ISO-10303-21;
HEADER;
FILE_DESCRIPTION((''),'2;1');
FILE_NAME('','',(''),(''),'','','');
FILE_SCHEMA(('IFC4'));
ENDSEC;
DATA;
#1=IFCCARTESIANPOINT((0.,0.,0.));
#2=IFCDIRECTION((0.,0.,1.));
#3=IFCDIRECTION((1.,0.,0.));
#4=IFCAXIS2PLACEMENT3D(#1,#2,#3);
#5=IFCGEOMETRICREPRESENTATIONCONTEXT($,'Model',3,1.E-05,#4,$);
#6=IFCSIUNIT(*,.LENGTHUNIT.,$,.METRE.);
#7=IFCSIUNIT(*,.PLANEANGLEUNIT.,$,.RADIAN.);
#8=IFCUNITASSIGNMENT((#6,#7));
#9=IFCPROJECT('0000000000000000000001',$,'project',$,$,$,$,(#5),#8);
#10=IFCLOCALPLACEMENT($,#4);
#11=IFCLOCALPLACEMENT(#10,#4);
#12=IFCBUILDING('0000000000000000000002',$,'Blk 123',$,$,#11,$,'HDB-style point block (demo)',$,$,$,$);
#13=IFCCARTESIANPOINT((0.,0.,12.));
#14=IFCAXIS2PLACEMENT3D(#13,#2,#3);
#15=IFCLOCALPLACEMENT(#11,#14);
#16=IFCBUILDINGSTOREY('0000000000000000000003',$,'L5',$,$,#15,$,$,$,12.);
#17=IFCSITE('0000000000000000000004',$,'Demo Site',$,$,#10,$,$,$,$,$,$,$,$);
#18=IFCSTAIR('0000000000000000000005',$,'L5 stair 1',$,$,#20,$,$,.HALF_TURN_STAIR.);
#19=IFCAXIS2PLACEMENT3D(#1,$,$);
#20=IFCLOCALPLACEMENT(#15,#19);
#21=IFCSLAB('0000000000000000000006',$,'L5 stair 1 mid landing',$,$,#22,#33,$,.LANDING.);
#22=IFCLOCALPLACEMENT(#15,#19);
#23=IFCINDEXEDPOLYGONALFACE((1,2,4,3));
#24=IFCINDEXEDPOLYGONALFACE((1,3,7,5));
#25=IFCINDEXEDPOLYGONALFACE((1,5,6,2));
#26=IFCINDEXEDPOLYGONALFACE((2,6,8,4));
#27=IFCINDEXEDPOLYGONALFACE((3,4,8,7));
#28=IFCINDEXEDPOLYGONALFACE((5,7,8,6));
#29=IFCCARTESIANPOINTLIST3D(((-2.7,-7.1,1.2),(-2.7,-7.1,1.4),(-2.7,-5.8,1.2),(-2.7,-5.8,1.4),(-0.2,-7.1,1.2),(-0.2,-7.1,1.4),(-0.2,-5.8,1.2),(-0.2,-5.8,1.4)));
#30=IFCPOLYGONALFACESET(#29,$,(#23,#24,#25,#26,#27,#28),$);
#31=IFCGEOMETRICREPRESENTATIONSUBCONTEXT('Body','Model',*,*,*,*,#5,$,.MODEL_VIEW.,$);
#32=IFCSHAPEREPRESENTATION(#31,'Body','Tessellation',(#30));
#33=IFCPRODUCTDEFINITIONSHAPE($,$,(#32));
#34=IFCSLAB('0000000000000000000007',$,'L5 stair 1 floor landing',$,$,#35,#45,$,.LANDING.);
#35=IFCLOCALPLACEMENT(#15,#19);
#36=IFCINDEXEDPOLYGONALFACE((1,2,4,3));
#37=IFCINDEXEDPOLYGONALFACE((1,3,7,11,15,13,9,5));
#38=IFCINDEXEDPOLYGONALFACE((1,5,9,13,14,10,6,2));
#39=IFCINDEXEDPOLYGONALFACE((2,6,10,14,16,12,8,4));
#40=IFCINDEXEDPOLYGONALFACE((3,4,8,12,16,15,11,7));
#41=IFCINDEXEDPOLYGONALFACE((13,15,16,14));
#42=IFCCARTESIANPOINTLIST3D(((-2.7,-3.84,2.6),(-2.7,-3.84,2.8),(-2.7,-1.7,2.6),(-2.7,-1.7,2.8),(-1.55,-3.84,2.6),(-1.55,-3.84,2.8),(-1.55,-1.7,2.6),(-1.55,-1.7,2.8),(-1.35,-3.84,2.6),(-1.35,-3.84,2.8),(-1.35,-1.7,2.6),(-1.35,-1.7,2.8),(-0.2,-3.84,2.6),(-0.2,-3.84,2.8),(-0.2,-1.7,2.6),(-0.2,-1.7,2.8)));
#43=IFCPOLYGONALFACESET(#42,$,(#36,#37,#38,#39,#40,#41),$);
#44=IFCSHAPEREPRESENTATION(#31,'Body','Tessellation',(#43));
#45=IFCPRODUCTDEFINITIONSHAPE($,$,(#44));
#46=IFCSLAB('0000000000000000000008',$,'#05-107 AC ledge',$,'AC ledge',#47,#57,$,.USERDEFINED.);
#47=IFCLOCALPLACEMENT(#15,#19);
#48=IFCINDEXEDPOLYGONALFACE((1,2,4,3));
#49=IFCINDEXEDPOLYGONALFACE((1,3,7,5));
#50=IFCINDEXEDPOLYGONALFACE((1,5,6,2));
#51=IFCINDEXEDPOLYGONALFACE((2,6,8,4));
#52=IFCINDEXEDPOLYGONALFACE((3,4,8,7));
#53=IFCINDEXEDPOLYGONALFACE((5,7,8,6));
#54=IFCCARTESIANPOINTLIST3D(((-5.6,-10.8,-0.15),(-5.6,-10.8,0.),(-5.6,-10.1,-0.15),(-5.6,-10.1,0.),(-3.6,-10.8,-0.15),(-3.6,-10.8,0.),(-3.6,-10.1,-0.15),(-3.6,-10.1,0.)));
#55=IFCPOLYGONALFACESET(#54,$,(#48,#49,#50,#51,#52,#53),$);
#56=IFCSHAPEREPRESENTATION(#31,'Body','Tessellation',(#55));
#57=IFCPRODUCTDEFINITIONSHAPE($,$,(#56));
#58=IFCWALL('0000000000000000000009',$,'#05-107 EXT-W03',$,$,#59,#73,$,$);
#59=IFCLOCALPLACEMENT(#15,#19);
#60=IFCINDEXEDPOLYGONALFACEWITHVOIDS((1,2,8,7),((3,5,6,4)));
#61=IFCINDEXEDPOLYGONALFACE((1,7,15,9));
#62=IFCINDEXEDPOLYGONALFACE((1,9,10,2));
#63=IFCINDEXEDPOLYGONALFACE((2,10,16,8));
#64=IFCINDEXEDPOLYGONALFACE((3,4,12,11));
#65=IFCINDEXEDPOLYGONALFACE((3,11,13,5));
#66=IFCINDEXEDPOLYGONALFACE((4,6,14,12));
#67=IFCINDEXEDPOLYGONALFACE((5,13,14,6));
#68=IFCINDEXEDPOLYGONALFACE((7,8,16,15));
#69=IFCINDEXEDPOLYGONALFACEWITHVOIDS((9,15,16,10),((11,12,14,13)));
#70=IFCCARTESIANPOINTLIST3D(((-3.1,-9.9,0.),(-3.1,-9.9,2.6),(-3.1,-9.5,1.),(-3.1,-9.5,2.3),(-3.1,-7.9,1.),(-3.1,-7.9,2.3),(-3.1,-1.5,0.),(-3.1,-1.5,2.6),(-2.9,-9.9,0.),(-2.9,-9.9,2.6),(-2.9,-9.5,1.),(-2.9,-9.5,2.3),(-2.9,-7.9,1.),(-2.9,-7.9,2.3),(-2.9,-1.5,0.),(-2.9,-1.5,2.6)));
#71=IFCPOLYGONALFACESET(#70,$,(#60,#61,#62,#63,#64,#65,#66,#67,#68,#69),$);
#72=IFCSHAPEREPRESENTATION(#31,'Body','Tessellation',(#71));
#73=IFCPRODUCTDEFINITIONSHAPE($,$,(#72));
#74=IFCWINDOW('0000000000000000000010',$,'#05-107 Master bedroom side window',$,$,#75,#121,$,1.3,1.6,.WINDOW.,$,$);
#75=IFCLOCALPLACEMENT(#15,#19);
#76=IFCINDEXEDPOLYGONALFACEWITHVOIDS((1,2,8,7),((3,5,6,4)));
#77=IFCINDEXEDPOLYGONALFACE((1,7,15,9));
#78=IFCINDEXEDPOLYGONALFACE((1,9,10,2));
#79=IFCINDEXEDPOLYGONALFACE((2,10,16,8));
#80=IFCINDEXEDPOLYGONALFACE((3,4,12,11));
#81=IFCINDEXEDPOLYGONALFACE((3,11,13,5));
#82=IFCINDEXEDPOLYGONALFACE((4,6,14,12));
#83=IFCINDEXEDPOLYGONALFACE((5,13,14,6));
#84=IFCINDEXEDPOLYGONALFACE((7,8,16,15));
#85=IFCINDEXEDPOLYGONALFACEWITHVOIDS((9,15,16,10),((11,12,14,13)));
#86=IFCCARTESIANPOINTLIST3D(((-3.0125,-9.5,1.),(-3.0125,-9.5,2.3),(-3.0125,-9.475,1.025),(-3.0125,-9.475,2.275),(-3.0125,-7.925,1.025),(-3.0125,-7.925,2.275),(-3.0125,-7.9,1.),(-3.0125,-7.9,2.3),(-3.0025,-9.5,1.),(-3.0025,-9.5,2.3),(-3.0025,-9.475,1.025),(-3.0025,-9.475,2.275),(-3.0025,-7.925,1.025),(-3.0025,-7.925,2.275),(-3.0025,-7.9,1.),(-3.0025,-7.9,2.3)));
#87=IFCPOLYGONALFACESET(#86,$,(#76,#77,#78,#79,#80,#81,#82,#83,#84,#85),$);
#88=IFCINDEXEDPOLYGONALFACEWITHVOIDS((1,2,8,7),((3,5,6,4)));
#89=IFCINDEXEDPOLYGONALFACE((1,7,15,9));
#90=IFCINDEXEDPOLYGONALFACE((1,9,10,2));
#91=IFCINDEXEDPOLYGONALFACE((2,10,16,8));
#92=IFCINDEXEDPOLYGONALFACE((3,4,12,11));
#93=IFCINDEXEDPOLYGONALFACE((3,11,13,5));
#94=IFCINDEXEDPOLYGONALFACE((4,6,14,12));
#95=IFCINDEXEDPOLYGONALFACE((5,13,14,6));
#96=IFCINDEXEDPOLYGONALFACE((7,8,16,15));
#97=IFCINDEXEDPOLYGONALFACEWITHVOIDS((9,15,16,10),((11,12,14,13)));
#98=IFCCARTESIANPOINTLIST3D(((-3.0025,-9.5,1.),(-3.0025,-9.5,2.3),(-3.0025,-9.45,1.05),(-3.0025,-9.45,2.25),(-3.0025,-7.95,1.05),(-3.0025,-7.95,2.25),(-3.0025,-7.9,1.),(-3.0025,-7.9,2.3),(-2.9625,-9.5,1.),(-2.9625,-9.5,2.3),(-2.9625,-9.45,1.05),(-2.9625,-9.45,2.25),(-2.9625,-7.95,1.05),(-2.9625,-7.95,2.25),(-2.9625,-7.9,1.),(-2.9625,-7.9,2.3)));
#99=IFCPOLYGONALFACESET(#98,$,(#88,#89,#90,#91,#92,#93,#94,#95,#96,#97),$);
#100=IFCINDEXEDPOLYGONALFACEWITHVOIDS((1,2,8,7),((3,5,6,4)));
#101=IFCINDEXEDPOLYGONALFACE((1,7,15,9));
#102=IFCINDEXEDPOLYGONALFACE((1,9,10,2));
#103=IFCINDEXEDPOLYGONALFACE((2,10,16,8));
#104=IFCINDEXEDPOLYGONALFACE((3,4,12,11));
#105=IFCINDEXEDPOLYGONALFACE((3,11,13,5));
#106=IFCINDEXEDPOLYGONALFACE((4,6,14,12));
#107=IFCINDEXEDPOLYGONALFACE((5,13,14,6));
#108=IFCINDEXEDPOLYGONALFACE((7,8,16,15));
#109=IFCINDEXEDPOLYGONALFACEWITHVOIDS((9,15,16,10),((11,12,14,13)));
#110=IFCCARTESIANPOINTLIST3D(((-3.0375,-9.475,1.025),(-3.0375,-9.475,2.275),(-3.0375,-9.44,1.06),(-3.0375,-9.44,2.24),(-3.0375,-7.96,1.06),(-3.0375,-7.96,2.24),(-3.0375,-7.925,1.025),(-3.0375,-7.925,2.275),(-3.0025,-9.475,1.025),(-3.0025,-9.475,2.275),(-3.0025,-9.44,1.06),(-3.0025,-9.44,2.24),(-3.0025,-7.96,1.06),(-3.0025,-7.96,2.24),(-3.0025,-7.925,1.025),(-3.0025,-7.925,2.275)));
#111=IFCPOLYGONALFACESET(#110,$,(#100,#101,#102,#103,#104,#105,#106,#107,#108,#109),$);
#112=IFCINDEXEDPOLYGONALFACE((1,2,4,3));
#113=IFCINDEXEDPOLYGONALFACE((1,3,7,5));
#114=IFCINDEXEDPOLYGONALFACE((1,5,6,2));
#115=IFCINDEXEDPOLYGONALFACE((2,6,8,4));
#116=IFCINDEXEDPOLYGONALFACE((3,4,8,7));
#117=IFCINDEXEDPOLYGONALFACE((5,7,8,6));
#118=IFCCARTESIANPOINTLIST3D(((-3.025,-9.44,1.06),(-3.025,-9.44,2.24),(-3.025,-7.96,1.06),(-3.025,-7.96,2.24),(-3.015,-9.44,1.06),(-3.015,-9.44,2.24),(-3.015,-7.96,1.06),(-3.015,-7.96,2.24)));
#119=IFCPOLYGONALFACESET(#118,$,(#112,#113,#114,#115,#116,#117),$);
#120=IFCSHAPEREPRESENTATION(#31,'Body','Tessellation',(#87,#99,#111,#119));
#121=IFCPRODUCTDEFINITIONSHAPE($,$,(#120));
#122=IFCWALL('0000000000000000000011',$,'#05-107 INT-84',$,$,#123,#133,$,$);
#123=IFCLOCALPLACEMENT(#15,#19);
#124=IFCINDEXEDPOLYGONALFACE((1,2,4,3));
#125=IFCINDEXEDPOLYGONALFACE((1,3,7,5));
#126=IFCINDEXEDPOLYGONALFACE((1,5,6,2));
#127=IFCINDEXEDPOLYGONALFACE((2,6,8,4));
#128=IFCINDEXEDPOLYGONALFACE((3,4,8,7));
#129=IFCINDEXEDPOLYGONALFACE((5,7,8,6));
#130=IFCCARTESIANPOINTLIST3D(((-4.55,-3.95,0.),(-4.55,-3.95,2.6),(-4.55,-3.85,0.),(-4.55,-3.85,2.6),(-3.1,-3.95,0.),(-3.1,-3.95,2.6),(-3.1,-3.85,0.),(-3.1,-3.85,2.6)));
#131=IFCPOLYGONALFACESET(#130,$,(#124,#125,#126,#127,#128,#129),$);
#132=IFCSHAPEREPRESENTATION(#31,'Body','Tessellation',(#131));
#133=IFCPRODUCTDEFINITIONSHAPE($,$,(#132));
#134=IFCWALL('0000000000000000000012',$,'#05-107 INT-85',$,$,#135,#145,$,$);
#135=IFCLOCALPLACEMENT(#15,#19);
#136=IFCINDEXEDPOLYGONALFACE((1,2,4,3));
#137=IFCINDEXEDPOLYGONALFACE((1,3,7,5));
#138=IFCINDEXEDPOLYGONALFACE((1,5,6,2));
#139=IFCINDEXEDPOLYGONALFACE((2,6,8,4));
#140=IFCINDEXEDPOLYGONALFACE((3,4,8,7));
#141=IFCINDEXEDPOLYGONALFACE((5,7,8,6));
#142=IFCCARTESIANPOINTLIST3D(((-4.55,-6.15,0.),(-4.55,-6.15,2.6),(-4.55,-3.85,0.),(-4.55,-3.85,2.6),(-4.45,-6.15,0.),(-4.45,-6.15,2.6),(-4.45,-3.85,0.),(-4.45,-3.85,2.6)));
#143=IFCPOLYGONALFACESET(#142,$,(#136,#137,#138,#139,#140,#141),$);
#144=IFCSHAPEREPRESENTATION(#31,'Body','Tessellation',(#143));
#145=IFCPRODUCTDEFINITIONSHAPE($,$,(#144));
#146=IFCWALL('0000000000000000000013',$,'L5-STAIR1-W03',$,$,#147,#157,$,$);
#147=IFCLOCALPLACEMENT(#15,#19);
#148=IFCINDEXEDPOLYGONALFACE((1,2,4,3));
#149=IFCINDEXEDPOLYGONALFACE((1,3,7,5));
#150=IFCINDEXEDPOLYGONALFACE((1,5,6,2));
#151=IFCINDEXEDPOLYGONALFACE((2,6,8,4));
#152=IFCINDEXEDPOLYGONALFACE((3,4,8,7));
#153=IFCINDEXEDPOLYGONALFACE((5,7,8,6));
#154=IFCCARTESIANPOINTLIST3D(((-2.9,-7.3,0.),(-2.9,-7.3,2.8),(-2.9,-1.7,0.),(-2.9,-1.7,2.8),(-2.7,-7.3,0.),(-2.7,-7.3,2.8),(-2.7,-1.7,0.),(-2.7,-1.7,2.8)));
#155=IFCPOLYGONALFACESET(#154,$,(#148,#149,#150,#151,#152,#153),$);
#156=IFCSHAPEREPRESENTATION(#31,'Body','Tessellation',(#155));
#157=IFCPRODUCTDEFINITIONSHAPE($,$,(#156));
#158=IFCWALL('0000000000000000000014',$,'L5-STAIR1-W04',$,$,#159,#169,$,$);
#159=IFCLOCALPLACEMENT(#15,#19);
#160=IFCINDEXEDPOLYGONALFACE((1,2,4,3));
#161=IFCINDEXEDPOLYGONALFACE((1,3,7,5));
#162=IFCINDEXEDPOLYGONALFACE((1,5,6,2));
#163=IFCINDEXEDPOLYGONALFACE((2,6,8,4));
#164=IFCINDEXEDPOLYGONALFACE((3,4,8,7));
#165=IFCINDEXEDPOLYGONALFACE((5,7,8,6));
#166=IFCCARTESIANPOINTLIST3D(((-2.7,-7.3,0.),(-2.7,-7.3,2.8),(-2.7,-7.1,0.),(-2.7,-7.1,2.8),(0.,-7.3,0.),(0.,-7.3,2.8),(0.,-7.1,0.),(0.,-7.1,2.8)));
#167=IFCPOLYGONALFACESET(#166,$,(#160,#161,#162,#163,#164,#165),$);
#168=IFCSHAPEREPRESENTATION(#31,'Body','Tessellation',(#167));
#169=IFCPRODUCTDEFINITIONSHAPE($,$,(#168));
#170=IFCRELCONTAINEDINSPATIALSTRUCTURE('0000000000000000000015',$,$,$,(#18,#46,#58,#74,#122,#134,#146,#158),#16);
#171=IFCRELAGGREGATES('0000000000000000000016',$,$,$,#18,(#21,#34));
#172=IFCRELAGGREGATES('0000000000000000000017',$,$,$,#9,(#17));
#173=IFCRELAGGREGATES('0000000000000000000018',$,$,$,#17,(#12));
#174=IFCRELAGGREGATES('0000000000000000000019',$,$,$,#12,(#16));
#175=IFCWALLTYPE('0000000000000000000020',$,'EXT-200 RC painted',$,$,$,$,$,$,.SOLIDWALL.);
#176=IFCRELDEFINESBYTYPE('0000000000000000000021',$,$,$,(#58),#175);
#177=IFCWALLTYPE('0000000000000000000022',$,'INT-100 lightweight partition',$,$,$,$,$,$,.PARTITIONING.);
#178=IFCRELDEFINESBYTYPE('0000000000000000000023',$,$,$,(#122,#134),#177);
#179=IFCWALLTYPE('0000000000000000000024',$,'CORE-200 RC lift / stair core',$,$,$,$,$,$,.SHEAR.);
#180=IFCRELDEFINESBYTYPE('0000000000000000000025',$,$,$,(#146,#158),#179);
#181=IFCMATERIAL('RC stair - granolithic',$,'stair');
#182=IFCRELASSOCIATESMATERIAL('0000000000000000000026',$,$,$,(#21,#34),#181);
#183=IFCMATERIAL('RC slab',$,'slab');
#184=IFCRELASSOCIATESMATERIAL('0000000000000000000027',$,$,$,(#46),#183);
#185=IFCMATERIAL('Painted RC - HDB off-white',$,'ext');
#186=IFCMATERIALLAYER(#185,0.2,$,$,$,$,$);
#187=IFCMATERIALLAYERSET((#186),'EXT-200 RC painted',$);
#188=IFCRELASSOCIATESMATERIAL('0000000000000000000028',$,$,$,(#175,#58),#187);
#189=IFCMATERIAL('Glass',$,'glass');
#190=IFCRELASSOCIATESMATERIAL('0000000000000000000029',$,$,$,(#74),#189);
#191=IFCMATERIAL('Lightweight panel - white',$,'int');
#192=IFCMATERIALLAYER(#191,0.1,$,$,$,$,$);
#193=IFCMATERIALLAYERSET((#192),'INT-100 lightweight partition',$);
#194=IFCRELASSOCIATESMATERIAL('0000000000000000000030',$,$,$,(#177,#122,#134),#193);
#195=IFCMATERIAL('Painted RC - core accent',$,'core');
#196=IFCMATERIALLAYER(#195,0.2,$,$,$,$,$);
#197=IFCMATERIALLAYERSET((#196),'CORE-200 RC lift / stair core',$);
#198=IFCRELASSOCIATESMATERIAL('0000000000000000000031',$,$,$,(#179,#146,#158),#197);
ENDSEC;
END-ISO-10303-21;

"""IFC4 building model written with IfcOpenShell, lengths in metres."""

from ifc_helpers import new_model, si_unit, frame, origin, origin_with_axes, place, context, subcontext, project, spatial, polyline, line, indexed_curve, outline, extrude, material, layer, layer_set, layer_usage, type_object, element, fill, aggregate, save


model = new_model("IFC4")

# Units and contexts
model_context = context("Model", 3, precision=1e-05, world=origin_with_axes())
body_context = subcontext(model_context, "Body", "Model", "MODEL_VIEW")
ifc_project = project(units=[si_unit("LENGTHUNIT", "METRE"), si_unit("PLANEANGLEUNIT", "RADIAN")], contexts=[model_context])

# Site, building, storey
site_placement = place(None, origin_with_axes())
site = spatial("IfcSite", under=ifc_project, at=site_placement, Name="Demo Site")
building_placement = place(site_placement, origin_with_axes())
building = spatial("IfcBuilding", under=site, at=building_placement, Name="Blk 123", LongName="HDB-style point block (demo)")
storey_placement = place(building_placement, frame((0.0, 0.0, 12.0), z_axis=(0.0, 0.0, 1.0), x_axis=(1.0, 0.0, 0.0)))
storey = spatial("IfcBuildingStorey", under=building, at=storey_placement, Name="L5", Elevation=12.0)

# Stair, slabs
stair_placement = place(storey_placement, frame((-2.7, -7.1, 0.0), z_axis=(0.0, 0.0, 1.0), x_axis=(1.0, 0.0, 0.0)))
stair = element("IfcStair", 1, at=stair_placement, inside=storey, Name="L5 stair 1", PredefinedType="HALF_TURN_STAIR")
ifc_material_1 = material(Name="RC stair - granolithic", Category="stair")
slab_1_placement = place(stair_placement, frame((1.25, 0.65, 1.2), z_axis=(0.0, 0.0, 1.0), x_axis=(1.0, 0.0, 0.0)))
slab_1 = element("IfcSlab", 2, at=slab_1_placement, material=ifc_material_1, Name="L5 stair 1 mid landing", PredefinedType="LANDING", context=body_context, shape_type="SweptSolid", body=[
    extrude(outline(polyline([(1.25, -0.65), (1.25, 0.65), (-1.25, 0.65), (-1.25, -0.65), (1.25, -0.65)])), origin(), (0.0, 0.0, 1.0), 0.2),
])
slab_2_placement = place(stair_placement, frame((1.25, 4.33, 2.6), z_axis=(0.0, 0.0, 1.0), x_axis=(1.0, 0.0, 0.0)))
slab_2 = element("IfcSlab", 3, at=slab_2_placement, material=ifc_material_1, Name="L5 stair 1 floor landing", PredefinedType="LANDING", context=body_context, shape_type="SweptSolid", body=[
    extrude(outline(polyline([(-0.1, 1.07), (-1.25, 1.07), (-1.25, -1.07), (-0.1, -1.07), (0.1, -1.07), (1.25, -1.07), (1.25, 1.07), (0.1, 1.07), (-0.1, 1.07)])), origin(), (0.0, 0.0, 1.0), 0.2),
])

# Slab
ifc_material_2 = material(Name="RC slab", Category="slab")
slab_3_placement = place(storey_placement, frame((-4.6, -10.45, -0.15), z_axis=(0.0, 0.0, 1.0), x_axis=(1.0, 0.0, 0.0)))
element("IfcSlab", 4, at=slab_3_placement, inside=storey, material=ifc_material_2, Name="#05-107 AC ledge", ObjectType="AC ledge", PredefinedType="USERDEFINED", context=body_context, shape_type="SweptSolid", body=[
    extrude(outline(polyline([(-1.0, 0.35), (-1.0, -0.35), (1.0, -0.35), (1.0, 0.35), (-1.0, 0.35)])), origin(), (0.0, 0.0, 1.0), 0.15),
])

# Wall, opening, window
ifc_material_3 = material(Name="Painted RC - HDB off-white", Category="ext")
ifc_layer_1 = layer(ifc_material_3, 0.2)
ifc_layer_set_1 = layer_set([ifc_layer_1], Name="EXT-200 RC painted")
ifc_layer_usage_1 = layer_usage(ifc_layer_set_1, "AXIS2", "POSITIVE", 0.0)
wall_type_1 = type_object("IfcWallType", Name="EXT-200 RC painted", PredefinedType="SOLIDWALL", material=ifc_layer_set_1)
wall_1_placement = place(storey_placement, frame((-2.9, -9.9, 0.0), z_axis=(0.0, 0.0, 1.0), x_axis=(0.0, 1.0, 0.0)))
wall_1 = element("IfcWall", 5, at=wall_1_placement, inside=storey, type_object=wall_type_1, material=ifc_layer_usage_1, Name="#05-107 EXT-W03", context=body_context, shape_type="SweptSolid", body=[
    extrude(outline(indexed_curve([(0.0, 0.0), (0.0, 0.2), (8.4, 0.2), (8.4, 0.0), (0.0, 0.0)], self_intersect=False)), origin_with_axes(), (0.0, 0.0, 1.0), 2.6),
])
opening_1_placement = place(wall_1_placement, frame((0.4, -0.1, 1.0), z_axis=(0.0, 0.0, 1.0), x_axis=(1.0, 0.0, 0.0)))
opening_1 = element("IfcOpeningElement", 6, at=opening_1_placement, cuts=wall_1, context=body_context, shape_type="SweptSolid", body=[
    extrude(outline(indexed_curve([(0.0, 0.0), (0.0, 0.4), (1.6, 0.4), (1.6, 0.0), (0.0, 0.0)], self_intersect=False)), origin_with_axes(), (0.0, 0.0, 1.0), 1.3),
])
ifc_material_4 = material(Name="Glass", Category="glass")
window_placement = place(opening_1_placement, frame((0.0, 0.1125, 0.0), z_axis=(0.0, 0.0, 1.0), x_axis=(1.0, 0.0, 0.0)))
window = element("IfcWindow", 7, at=window_placement, inside=storey, material=ifc_material_4, Name="#05-107 Master bedroom side window", OverallHeight=1.3, OverallWidth=1.6, PredefinedType="WINDOW", context=body_context, shape_type="SweptSolid", body=[
    extrude(outline(indexed_curve([(0.0, 0.0), (1.6, 0.0), (1.6, 1.3), (0.0, 1.3)], segments=[line(1, 2, 3, 4, 1)]), holes=[indexed_curve([(0.025, 0.025), (1.575, 0.025), (1.575, 1.275), (0.025, 1.275)], segments=[line(1, 2, 3, 4, 1)])]), frame((0.0, 0.09, 0.0), z_axis=(0.0, -1.0, 0.0), x_axis=(1.0, 0.0, 0.0)), (0.0, 0.0, -1.0), 0.01),
    extrude(outline(indexed_curve([(0.0, 0.0), (1.6, 0.0), (1.6, 1.3), (0.0, 1.3)], segments=[line(1, 2, 3, 4, 1)]), holes=[indexed_curve([(0.05, 0.05), (1.55, 0.05), (1.55, 1.25), (0.05, 1.25)], segments=[line(1, 2, 3, 4, 1)])]), frame((0.0, 0.05, 0.0), z_axis=(0.0, -1.0, 0.0), x_axis=(1.0, 0.0, 0.0)), (0.0, 0.0, -1.0), 0.04),
    extrude(outline(indexed_curve([(0.0, 0.0), (1.55, 0.0), (1.55, 1.25), (0.0, 1.25)], segments=[line(1, 2, 3, 4, 1)]), holes=[indexed_curve([(0.035, 0.035), (1.515, 0.035), (1.515, 1.215), (0.035, 1.215)], segments=[line(1, 2, 3, 4, 1)])]), frame((0.025, 0.09, 0.025), z_axis=(0.0, -1.0, 0.0), x_axis=(1.0, 0.0, 0.0)), (0.0, 0.0, -1.0), 0.035),
    extrude(outline(indexed_curve([(0.035, 0.035), (1.515, 0.035), (1.515, 1.215), (0.035, 1.215)], segments=[line(1, 2, 3, 4, 1)])), frame((0.025, 0.1025, 0.025), z_axis=(0.0, -1.0, 0.0), x_axis=(1.0, 0.0, 0.0)), (0.0, 0.0, -1.0), 0.01),
])
fill(opening_1, window)

# Shared definitions
ifc_material_5 = material(Name="Lightweight panel - white", Category="int")
ifc_layer_2 = layer(ifc_material_5, 0.1)
ifc_layer_set_2 = layer_set([ifc_layer_2], Name="INT-100 lightweight partition")
ifc_layer_usage_2 = layer_usage(ifc_layer_set_2, "AXIS2", "POSITIVE", -0.05)
wall_type_2 = type_object("IfcWallType", Name="INT-100 lightweight partition", PredefinedType="PARTITIONING", material=ifc_layer_set_2)

# Walls
wall_2_placement = place(storey_placement, frame((-3.1, -3.9, 0.0), z_axis=(0.0, 0.0, 1.0), x_axis=(-1.0, 0.0, 0.0)))
element("IfcWall", 8, at=wall_2_placement, inside=storey, type_object=wall_type_2, material=ifc_layer_usage_2, Name="#05-107 INT-84", context=body_context, shape_type="SweptSolid", body=[
    extrude(outline(indexed_curve([(0.0, 0.0), (0.0, 0.1), (1.45, 0.1), (1.45, 0.0), (0.0, 0.0)], self_intersect=False)), frame((0.0, -0.05, 0.0), z_axis=(0.0, 0.0, 1.0), x_axis=(1.0, 0.0, 0.0)), (0.0, 0.0, 1.0), 2.6),
])
wall_3_placement = place(storey_placement, frame((-4.5, -3.85, 0.0), z_axis=(0.0, 0.0, 1.0), x_axis=(0.0, -1.0, 0.0)))
element("IfcWall", 9, at=wall_3_placement, inside=storey, type_object=wall_type_2, material=ifc_layer_usage_2, Name="#05-107 INT-85", context=body_context, shape_type="SweptSolid", body=[
    extrude(outline(indexed_curve([(0.0, 0.0), (0.0, 0.1), (2.3, 0.1), (2.3, 0.0), (0.0, 0.0)], self_intersect=False)), frame((0.0, -0.05, 0.0), z_axis=(0.0, 0.0, 1.0), x_axis=(1.0, 0.0, 0.0)), (0.0, 0.0, 1.0), 2.6),
])

# Walls
ifc_material_6 = material(Name="Painted RC - core accent", Category="core")
ifc_layer_3 = layer(ifc_material_6, 0.2)
ifc_layer_set_3 = layer_set([ifc_layer_3], Name="CORE-200 RC lift / stair core")
ifc_layer_usage_3 = layer_usage(ifc_layer_set_3, "AXIS2", "POSITIVE", 0.0)
wall_type_3 = type_object("IfcWallType", Name="CORE-200 RC lift / stair core", PredefinedType="SHEAR", material=ifc_layer_set_3)
wall_4_placement = place(storey_placement, frame((-2.9, -1.7, 0.0), z_axis=(0.0, 0.0, 1.0), x_axis=(0.0, -1.0, 0.0)))
element("IfcWall", 10, at=wall_4_placement, inside=storey, type_object=wall_type_3, material=ifc_layer_usage_3, Name="L5-STAIR1-W03", context=body_context, shape_type="SweptSolid", body=[
    extrude(outline(indexed_curve([(0.0, 0.0), (0.0, 0.2), (5.6, 0.2), (5.6, 0.0), (0.0, 0.0)], self_intersect=False)), origin_with_axes(), (0.0, 0.0, 1.0), 2.8),
])
wall_5_placement = place(storey_placement, frame((-2.7, -7.3, 0.0), z_axis=(0.0, 0.0, 1.0), x_axis=(1.0, 0.0, 0.0)))
element("IfcWall", 11, at=wall_5_placement, inside=storey, type_object=wall_type_3, material=ifc_layer_usage_3, Name="L5-STAIR1-W04", context=body_context, shape_type="SweptSolid", body=[
    extrude(outline(indexed_curve([(0.0, 0.0), (0.0, 0.2), (2.7, 0.2), (2.7, 0.0), (0.0, 0.0)], self_intersect=False)), origin_with_axes(), (0.0, 0.0, 1.0), 2.8),
])

aggregate(stair, [slab_1, slab_2])

save(model, "model.ifc")
